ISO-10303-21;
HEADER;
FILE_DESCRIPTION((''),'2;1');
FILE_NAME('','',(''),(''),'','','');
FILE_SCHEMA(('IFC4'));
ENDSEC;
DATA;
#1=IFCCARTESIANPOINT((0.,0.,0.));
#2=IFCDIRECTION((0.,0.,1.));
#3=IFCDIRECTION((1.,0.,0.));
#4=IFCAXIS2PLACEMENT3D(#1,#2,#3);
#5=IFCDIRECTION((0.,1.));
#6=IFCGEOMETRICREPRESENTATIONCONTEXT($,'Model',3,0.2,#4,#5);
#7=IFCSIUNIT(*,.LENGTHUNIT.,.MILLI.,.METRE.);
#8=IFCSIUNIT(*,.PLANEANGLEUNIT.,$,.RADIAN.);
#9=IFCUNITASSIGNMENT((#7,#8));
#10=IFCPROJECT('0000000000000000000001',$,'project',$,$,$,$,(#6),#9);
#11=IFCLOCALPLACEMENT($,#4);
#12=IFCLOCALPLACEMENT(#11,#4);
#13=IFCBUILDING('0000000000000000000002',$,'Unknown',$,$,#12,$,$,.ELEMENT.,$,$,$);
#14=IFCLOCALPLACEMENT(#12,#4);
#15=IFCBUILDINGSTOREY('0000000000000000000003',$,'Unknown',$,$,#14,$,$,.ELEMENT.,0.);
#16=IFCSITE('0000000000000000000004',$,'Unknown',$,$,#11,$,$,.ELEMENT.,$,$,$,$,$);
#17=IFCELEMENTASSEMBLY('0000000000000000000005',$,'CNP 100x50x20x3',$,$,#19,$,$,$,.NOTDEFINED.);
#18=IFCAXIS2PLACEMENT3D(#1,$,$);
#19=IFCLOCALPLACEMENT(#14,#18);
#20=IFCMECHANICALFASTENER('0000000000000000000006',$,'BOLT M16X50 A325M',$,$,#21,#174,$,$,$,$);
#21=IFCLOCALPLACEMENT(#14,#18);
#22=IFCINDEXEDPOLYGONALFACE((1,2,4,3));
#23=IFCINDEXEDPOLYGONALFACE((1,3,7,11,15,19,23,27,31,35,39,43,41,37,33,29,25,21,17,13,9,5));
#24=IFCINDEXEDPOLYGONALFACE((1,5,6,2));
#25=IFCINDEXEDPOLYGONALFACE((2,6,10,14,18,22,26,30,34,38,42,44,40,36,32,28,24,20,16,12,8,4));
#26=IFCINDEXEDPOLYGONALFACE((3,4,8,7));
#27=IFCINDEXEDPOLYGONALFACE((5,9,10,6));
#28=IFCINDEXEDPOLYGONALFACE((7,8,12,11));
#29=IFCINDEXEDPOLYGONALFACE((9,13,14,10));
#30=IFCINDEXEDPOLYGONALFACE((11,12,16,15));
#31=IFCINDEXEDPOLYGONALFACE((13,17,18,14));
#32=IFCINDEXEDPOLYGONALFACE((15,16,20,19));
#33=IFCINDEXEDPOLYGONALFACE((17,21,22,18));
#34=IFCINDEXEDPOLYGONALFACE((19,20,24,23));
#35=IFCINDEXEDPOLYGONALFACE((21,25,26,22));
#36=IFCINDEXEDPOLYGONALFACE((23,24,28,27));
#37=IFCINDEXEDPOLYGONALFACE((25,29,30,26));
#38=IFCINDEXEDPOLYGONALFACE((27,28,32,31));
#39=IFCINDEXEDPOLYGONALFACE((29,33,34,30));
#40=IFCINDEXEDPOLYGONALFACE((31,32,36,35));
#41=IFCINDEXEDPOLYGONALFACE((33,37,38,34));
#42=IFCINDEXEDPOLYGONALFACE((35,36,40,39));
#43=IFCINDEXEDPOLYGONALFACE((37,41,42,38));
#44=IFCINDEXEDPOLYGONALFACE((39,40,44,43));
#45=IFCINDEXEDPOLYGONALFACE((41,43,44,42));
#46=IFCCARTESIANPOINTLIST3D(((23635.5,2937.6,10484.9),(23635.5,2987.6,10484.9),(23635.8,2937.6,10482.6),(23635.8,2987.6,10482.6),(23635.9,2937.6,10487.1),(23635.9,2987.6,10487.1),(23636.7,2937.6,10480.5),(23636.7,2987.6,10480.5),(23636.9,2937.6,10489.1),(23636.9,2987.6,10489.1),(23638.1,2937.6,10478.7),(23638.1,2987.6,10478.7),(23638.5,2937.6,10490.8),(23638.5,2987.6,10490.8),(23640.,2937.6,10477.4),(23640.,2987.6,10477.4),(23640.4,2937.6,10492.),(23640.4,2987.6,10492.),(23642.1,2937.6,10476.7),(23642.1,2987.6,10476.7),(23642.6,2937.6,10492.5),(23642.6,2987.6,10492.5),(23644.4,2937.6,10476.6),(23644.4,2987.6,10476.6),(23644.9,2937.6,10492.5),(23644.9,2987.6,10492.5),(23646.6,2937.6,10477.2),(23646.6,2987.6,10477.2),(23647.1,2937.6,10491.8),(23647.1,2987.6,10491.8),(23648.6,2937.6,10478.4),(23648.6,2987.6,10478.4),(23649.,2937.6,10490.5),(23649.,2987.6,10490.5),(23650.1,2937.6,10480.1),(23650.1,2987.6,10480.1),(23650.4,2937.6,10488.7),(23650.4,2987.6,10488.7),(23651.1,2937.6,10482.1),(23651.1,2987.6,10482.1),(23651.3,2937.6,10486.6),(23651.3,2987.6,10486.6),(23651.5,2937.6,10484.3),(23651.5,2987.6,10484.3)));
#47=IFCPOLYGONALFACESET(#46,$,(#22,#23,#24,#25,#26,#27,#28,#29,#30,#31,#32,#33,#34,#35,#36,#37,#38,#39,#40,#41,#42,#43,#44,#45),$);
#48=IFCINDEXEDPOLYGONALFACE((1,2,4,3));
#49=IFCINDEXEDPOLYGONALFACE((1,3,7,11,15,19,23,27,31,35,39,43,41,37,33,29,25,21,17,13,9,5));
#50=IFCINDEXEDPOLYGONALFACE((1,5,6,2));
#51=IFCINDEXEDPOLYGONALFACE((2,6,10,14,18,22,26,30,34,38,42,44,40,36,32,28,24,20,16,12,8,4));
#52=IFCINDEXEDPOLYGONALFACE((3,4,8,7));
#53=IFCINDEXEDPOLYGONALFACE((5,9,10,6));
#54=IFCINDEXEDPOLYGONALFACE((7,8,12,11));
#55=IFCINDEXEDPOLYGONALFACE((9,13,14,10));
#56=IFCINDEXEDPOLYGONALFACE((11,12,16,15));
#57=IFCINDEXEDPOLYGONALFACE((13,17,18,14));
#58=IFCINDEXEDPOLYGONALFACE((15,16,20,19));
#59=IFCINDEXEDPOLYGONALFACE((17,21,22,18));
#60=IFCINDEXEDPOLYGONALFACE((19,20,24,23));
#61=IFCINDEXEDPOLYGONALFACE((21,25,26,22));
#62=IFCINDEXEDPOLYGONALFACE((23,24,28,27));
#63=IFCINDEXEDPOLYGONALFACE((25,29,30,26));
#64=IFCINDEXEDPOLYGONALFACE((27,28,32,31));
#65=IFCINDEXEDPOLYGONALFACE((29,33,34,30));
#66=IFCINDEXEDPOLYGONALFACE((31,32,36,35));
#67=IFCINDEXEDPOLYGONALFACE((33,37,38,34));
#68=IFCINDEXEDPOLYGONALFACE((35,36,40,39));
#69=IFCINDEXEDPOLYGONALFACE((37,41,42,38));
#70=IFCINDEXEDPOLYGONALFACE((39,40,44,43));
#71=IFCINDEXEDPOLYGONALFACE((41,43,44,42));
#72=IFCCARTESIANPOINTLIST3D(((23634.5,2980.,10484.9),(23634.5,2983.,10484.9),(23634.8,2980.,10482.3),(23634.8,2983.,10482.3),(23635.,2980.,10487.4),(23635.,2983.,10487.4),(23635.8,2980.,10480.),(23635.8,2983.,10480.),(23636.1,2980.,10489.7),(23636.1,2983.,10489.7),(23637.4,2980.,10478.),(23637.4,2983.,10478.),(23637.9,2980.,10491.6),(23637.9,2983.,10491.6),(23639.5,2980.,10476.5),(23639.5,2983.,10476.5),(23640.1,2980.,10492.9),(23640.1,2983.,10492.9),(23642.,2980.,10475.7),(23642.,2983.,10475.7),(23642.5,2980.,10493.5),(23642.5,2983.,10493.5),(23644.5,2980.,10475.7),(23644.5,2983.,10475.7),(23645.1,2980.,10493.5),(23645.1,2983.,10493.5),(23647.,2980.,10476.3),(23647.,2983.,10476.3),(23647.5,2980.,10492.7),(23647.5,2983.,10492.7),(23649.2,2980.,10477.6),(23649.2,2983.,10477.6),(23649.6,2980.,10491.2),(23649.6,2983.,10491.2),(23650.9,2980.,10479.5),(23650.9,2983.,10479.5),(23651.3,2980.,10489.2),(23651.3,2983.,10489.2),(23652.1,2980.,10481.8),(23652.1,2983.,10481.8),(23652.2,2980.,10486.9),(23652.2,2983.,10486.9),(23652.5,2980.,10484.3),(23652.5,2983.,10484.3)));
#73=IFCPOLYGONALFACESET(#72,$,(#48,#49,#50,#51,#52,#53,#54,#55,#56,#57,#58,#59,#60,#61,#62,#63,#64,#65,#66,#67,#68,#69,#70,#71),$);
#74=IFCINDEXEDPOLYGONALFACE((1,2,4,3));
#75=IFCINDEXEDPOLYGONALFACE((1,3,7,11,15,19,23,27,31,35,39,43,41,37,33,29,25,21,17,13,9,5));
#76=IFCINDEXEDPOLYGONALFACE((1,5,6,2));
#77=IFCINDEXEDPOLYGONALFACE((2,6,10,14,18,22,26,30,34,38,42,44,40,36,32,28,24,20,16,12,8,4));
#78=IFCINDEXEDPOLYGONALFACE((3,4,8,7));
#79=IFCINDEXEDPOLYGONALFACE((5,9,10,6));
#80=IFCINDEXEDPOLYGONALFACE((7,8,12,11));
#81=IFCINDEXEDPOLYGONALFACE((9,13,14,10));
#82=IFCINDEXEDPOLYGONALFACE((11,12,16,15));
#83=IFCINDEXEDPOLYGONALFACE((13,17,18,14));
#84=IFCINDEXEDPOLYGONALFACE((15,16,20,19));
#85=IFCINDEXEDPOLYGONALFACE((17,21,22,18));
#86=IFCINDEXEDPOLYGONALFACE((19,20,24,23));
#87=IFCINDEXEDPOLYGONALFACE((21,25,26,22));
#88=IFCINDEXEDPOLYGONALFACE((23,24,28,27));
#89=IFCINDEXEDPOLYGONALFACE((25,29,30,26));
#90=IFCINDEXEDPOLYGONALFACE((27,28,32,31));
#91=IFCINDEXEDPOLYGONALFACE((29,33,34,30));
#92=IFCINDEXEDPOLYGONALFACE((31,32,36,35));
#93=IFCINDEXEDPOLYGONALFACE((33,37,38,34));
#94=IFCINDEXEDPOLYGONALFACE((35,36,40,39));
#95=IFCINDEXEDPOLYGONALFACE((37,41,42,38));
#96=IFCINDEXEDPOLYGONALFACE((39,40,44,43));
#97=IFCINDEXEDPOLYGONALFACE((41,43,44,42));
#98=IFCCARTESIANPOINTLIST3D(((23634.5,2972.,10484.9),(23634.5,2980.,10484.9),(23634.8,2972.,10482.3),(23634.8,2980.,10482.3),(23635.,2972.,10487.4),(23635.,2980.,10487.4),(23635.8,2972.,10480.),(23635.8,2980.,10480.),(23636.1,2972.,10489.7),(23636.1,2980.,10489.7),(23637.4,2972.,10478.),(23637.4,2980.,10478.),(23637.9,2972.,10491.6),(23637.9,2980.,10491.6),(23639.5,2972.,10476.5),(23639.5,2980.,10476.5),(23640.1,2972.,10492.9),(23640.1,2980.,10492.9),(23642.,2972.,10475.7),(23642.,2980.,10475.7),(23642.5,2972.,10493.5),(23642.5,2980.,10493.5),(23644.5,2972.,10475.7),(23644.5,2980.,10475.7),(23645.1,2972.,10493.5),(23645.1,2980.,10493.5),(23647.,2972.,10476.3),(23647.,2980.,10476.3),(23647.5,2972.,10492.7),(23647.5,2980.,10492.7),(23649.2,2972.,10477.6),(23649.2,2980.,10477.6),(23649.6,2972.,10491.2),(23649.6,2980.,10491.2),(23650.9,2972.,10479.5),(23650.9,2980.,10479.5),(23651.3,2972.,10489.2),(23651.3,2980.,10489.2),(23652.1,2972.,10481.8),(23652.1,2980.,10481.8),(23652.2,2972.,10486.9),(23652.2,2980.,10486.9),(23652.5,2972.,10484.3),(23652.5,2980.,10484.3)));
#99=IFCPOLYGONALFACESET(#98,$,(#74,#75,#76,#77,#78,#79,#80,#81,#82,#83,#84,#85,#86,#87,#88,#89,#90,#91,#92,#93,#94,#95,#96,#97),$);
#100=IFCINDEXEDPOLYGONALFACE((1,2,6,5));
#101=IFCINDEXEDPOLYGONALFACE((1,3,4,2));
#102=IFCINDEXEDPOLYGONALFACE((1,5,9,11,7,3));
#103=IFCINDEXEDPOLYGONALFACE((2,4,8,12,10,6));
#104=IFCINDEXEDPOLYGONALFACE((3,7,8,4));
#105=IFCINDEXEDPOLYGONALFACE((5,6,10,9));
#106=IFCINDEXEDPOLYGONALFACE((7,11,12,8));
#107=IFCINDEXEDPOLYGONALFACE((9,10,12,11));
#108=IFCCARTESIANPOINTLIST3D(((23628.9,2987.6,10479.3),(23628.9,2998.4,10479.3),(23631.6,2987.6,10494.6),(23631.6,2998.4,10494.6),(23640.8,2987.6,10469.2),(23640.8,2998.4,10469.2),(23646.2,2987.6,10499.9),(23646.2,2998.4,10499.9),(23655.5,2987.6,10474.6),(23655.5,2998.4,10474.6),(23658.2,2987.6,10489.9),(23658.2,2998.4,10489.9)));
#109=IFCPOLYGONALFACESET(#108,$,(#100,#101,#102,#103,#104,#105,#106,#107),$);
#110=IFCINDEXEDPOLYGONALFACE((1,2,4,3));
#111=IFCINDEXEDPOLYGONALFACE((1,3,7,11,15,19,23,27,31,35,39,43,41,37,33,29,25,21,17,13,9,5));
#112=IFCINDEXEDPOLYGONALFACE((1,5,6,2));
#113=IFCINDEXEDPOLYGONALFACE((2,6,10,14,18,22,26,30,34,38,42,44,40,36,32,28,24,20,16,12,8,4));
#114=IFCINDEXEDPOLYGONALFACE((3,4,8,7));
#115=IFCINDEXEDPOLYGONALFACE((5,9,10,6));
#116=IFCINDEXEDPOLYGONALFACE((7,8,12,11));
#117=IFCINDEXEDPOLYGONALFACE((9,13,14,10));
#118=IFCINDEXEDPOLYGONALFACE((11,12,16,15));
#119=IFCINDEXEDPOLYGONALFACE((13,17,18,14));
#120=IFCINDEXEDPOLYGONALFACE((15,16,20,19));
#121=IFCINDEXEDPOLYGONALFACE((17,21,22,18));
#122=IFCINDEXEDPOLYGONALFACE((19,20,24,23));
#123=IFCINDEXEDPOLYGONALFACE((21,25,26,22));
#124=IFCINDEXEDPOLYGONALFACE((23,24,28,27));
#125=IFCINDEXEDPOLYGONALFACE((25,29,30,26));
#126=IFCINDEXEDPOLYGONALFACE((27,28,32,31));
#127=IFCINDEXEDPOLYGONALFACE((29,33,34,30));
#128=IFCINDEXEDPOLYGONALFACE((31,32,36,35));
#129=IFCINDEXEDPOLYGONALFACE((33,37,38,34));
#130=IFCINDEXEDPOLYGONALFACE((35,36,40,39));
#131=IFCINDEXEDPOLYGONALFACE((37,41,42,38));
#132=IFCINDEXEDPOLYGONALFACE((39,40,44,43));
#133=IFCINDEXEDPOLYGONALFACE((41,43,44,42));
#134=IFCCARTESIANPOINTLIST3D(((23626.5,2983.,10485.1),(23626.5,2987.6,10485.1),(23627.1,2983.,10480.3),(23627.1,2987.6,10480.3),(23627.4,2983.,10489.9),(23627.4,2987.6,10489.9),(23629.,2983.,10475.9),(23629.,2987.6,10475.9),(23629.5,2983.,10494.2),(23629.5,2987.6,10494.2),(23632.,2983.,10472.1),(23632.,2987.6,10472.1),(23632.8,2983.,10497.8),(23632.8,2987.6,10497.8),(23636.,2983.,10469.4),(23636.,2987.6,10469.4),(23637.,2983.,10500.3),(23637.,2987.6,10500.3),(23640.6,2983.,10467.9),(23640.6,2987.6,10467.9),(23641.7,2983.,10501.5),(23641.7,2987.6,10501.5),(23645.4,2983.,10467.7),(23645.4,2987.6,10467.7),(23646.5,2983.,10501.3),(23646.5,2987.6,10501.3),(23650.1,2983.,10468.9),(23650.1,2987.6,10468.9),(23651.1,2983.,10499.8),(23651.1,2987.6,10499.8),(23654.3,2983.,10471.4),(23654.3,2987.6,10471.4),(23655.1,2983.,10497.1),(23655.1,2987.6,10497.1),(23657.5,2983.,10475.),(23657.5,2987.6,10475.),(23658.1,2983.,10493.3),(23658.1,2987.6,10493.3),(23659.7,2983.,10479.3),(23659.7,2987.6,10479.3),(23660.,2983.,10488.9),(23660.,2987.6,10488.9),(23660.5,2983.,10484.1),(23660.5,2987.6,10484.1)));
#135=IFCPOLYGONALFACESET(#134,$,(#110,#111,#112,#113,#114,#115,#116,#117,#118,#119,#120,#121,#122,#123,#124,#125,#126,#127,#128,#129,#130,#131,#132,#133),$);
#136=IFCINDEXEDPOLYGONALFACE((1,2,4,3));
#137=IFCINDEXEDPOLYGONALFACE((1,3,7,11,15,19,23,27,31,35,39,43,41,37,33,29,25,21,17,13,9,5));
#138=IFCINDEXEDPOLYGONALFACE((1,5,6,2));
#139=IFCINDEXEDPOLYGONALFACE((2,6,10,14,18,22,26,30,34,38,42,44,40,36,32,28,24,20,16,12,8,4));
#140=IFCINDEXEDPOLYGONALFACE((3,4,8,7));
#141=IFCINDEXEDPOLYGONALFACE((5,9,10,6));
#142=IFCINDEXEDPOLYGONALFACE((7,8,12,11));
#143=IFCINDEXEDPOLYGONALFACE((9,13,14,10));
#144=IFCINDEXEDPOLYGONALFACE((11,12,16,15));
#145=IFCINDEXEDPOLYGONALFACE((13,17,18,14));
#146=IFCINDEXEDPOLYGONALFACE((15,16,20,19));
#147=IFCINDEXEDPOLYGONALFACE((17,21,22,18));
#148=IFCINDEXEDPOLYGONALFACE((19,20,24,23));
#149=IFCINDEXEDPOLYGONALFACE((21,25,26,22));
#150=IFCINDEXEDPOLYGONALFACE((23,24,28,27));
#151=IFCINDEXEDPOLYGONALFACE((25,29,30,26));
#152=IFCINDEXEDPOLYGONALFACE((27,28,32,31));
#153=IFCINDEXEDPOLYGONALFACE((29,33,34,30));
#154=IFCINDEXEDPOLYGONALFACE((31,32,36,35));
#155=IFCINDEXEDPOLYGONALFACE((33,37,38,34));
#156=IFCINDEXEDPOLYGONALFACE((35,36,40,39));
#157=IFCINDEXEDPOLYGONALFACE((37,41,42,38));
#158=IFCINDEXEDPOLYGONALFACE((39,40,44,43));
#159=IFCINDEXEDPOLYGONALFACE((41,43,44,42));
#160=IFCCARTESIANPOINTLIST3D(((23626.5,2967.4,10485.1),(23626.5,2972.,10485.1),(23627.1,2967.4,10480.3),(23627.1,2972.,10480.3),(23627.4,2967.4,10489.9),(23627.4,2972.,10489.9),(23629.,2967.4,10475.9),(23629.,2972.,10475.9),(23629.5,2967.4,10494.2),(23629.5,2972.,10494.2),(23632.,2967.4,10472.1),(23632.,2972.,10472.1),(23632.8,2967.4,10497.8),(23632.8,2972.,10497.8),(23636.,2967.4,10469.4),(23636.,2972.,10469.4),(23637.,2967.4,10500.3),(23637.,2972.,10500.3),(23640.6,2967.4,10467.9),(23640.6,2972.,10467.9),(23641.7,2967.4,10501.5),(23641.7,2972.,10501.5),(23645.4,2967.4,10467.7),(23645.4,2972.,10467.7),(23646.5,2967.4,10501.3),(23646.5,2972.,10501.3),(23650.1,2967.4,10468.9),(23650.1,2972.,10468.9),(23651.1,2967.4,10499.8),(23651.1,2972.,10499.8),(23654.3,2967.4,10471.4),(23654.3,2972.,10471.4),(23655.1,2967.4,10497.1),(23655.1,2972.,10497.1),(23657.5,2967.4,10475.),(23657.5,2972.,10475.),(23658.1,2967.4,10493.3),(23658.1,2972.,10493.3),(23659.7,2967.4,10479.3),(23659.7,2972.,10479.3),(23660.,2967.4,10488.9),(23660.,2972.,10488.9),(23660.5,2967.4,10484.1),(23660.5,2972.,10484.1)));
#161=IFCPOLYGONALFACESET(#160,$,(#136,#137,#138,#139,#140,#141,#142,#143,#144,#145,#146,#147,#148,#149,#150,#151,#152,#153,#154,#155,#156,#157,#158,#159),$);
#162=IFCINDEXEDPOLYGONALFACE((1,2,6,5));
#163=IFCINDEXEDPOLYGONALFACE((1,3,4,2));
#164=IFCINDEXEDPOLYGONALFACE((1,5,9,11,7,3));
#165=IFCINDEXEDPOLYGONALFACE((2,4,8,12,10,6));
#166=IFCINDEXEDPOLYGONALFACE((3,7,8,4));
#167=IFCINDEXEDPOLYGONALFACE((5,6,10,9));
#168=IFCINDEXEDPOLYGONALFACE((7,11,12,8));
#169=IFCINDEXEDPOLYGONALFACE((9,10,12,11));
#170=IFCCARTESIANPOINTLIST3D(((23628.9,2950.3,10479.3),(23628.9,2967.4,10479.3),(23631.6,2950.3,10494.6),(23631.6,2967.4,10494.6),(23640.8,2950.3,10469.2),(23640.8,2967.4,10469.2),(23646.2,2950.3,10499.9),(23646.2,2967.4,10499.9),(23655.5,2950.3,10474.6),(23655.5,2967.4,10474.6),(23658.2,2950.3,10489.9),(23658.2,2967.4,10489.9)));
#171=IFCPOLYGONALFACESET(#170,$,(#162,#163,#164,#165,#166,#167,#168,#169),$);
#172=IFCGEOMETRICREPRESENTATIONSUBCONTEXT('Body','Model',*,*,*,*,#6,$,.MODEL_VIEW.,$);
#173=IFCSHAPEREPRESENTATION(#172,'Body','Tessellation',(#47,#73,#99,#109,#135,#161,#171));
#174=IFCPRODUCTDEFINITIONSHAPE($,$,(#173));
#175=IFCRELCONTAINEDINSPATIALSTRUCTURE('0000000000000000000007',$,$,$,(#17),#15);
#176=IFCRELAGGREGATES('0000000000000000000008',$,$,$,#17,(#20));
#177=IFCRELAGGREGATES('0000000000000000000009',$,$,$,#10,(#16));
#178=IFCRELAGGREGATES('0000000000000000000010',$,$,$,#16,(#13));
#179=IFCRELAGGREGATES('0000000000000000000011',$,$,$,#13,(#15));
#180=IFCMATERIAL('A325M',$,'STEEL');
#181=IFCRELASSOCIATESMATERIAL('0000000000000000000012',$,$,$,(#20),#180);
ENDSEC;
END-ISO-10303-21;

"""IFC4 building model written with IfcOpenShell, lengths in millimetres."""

from ifc_helpers import new_model, si_unit, direction, frame, origin_with_axes, place, context, subcontext, project, spatial, line, arc, indexed_curve, outline, extrude, source, transform, mapped, material, element, aggregate, save


model = new_model("IFC4")

# Units and contexts
model_context = context("Model", 3, precision=0.2, world=origin_with_axes(), true_north=direction((0.0, 1.0)))
body_context = subcontext(model_context, "Body", "Model", "MODEL_VIEW")
ifc_project = project(units=[si_unit("LENGTHUNIT", "METRE", prefix="MILLI"), si_unit("PLANEANGLEUNIT", "RADIAN")], contexts=[model_context])

# Site, building, storey
site_placement = place(None, origin_with_axes())
site = spatial("IfcSite", under=ifc_project, at=site_placement, Name="Unknown", CompositionType="ELEMENT")
building_placement = place(site_placement, origin_with_axes())
building = spatial("IfcBuilding", under=site, at=building_placement, Name="Unknown", CompositionType="ELEMENT")
storey_placement = place(building_placement, origin_with_axes())
storey = spatial("IfcBuildingStorey", under=building, at=storey_placement, Name="Unknown", CompositionType="ELEMENT", Elevation=0.0)

# Shared definitions
ifc_material_1 = material(Name="A325M", Category="STEEL")
shared_shape = source(origin_with_axes(), body_context, "Body", "SweptSolid", [
    extrude(outline(indexed_curve([(8.0, 0.0), (0.0, 8.0), (-8.0, 0.0), (0.0, -8.0)], segments=[arc(1, 2, 3), arc(3, 4, 1)])), frame((0.0, 0.0, 15.6), z_axis=(0.0, 0.0, -1.0), x_axis=(0.0, 1.0, 0.0)), (0.0, 0.0, 1.0), 50.0),
    extrude(outline(indexed_curve([(9.0, 0.0), (0.0, 9.0), (-9.0, 0.0), (0.0, -9.0)], segments=[arc(1, 2, 3), arc(3, 4, 1)])), frame((0.0, 0.0, 11.0), z_axis=(0.0, 0.0, -1.0), x_axis=(0.0, 1.0, 0.0)), (0.0, 0.0, 1.0), 3.0),
    extrude(outline(indexed_curve([(9.0, 0.0), (0.0, 9.0), (-9.0, 0.0), (0.0, -9.0)], segments=[arc(1, 2, 3), arc(3, 4, 1)])), frame((0.0, 0.0, 8.0), z_axis=(0.0, 0.0, -1.0), x_axis=(0.0, 1.0, 0.0)), (0.0, 0.0, 1.0), 8.0),
    extrude(outline(indexed_curve([(15.6, 0.0), (7.8, 13.5), (-7.8, 13.5), (-15.6, 0.0), (-7.8, -13.5), (7.8, -13.5)], segments=[line(1, 2, 3, 4, 5, 6, 1)])), frame((0.0, 0.0, 26.4), z_axis=(0.0, 0.0, -1.0), x_axis=(0.0, 1.0, 0.0)), (0.0, 0.0, 1.0), 10.8),
    extrude(outline(indexed_curve([(17.0, 0.0), (0.0, 17.0), (-17.0, 0.0), (0.0, -17.0)], segments=[arc(1, 2, 3), arc(3, 4, 1)])), frame((0.0, 0.0, 15.6), z_axis=(0.0, 0.0, -1.0), x_axis=(0.0, 1.0, 0.0)), (0.0, 0.0, 1.0), 4.6),
    extrude(outline(indexed_curve([(17.0, 0.0), (0.0, 17.0), (-17.0, 0.0), (0.0, -17.0)], segments=[arc(1, 2, 3), arc(3, 4, 1)])), frame((0.0, 0.0, 0.0), z_axis=(0.0, 0.0, -1.0), x_axis=(0.0, 1.0, 0.0)), (0.0, 0.0, 1.0), 4.6),
    extrude(outline(indexed_curve([(15.6, 0.0), (7.8, 13.5), (-7.8, 13.5), (-15.6, 0.0), (-7.8, -13.5), (7.8, -13.5)], segments=[line(1, 2, 3, 4, 5, 6, 1)])), frame((0.0, 0.0, -4.6), z_axis=(0.0, 0.0, -1.0), x_axis=(0.0, 1.0, 0.0)), (0.0, 0.0, 1.0), 17.1),
])

# Element assembly, mechanical fastener
assembly_1_placement = place(storey_placement, frame((25552.5, 3005.0, 10153.1), z_axis=(0.173648, 0.0, 0.984808), x_axis=(-0.984808, 0.0, 0.173648)))
assembly_1 = element("IfcElementAssembly", 1, at=assembly_1_placement, inside=storey, Name="CNP 100x50x20x3", PredefinedType="NOTDEFINED")
mechanical_fastener_1_placement = place(assembly_1_placement, frame((1937.5, 33.0, -5.0), z_axis=(0.0, -1.0, 0.0), x_axis=(-1.0, 0.0, 0.0)))
mechanical_fastener_1 = element("IfcMechanicalFastener", 2, at=mechanical_fastener_1_placement, material=ifc_material_1, Name="BOLT M16X50 A325M", context=body_context, shape_type="MappedRepresentation", body=[
    mapped(shared_shape, transform((0.0, 0.0, 0.0))),
])
aggregate(assembly_1, [mechanical_fastener_1])

save(model, "model.ifc")
